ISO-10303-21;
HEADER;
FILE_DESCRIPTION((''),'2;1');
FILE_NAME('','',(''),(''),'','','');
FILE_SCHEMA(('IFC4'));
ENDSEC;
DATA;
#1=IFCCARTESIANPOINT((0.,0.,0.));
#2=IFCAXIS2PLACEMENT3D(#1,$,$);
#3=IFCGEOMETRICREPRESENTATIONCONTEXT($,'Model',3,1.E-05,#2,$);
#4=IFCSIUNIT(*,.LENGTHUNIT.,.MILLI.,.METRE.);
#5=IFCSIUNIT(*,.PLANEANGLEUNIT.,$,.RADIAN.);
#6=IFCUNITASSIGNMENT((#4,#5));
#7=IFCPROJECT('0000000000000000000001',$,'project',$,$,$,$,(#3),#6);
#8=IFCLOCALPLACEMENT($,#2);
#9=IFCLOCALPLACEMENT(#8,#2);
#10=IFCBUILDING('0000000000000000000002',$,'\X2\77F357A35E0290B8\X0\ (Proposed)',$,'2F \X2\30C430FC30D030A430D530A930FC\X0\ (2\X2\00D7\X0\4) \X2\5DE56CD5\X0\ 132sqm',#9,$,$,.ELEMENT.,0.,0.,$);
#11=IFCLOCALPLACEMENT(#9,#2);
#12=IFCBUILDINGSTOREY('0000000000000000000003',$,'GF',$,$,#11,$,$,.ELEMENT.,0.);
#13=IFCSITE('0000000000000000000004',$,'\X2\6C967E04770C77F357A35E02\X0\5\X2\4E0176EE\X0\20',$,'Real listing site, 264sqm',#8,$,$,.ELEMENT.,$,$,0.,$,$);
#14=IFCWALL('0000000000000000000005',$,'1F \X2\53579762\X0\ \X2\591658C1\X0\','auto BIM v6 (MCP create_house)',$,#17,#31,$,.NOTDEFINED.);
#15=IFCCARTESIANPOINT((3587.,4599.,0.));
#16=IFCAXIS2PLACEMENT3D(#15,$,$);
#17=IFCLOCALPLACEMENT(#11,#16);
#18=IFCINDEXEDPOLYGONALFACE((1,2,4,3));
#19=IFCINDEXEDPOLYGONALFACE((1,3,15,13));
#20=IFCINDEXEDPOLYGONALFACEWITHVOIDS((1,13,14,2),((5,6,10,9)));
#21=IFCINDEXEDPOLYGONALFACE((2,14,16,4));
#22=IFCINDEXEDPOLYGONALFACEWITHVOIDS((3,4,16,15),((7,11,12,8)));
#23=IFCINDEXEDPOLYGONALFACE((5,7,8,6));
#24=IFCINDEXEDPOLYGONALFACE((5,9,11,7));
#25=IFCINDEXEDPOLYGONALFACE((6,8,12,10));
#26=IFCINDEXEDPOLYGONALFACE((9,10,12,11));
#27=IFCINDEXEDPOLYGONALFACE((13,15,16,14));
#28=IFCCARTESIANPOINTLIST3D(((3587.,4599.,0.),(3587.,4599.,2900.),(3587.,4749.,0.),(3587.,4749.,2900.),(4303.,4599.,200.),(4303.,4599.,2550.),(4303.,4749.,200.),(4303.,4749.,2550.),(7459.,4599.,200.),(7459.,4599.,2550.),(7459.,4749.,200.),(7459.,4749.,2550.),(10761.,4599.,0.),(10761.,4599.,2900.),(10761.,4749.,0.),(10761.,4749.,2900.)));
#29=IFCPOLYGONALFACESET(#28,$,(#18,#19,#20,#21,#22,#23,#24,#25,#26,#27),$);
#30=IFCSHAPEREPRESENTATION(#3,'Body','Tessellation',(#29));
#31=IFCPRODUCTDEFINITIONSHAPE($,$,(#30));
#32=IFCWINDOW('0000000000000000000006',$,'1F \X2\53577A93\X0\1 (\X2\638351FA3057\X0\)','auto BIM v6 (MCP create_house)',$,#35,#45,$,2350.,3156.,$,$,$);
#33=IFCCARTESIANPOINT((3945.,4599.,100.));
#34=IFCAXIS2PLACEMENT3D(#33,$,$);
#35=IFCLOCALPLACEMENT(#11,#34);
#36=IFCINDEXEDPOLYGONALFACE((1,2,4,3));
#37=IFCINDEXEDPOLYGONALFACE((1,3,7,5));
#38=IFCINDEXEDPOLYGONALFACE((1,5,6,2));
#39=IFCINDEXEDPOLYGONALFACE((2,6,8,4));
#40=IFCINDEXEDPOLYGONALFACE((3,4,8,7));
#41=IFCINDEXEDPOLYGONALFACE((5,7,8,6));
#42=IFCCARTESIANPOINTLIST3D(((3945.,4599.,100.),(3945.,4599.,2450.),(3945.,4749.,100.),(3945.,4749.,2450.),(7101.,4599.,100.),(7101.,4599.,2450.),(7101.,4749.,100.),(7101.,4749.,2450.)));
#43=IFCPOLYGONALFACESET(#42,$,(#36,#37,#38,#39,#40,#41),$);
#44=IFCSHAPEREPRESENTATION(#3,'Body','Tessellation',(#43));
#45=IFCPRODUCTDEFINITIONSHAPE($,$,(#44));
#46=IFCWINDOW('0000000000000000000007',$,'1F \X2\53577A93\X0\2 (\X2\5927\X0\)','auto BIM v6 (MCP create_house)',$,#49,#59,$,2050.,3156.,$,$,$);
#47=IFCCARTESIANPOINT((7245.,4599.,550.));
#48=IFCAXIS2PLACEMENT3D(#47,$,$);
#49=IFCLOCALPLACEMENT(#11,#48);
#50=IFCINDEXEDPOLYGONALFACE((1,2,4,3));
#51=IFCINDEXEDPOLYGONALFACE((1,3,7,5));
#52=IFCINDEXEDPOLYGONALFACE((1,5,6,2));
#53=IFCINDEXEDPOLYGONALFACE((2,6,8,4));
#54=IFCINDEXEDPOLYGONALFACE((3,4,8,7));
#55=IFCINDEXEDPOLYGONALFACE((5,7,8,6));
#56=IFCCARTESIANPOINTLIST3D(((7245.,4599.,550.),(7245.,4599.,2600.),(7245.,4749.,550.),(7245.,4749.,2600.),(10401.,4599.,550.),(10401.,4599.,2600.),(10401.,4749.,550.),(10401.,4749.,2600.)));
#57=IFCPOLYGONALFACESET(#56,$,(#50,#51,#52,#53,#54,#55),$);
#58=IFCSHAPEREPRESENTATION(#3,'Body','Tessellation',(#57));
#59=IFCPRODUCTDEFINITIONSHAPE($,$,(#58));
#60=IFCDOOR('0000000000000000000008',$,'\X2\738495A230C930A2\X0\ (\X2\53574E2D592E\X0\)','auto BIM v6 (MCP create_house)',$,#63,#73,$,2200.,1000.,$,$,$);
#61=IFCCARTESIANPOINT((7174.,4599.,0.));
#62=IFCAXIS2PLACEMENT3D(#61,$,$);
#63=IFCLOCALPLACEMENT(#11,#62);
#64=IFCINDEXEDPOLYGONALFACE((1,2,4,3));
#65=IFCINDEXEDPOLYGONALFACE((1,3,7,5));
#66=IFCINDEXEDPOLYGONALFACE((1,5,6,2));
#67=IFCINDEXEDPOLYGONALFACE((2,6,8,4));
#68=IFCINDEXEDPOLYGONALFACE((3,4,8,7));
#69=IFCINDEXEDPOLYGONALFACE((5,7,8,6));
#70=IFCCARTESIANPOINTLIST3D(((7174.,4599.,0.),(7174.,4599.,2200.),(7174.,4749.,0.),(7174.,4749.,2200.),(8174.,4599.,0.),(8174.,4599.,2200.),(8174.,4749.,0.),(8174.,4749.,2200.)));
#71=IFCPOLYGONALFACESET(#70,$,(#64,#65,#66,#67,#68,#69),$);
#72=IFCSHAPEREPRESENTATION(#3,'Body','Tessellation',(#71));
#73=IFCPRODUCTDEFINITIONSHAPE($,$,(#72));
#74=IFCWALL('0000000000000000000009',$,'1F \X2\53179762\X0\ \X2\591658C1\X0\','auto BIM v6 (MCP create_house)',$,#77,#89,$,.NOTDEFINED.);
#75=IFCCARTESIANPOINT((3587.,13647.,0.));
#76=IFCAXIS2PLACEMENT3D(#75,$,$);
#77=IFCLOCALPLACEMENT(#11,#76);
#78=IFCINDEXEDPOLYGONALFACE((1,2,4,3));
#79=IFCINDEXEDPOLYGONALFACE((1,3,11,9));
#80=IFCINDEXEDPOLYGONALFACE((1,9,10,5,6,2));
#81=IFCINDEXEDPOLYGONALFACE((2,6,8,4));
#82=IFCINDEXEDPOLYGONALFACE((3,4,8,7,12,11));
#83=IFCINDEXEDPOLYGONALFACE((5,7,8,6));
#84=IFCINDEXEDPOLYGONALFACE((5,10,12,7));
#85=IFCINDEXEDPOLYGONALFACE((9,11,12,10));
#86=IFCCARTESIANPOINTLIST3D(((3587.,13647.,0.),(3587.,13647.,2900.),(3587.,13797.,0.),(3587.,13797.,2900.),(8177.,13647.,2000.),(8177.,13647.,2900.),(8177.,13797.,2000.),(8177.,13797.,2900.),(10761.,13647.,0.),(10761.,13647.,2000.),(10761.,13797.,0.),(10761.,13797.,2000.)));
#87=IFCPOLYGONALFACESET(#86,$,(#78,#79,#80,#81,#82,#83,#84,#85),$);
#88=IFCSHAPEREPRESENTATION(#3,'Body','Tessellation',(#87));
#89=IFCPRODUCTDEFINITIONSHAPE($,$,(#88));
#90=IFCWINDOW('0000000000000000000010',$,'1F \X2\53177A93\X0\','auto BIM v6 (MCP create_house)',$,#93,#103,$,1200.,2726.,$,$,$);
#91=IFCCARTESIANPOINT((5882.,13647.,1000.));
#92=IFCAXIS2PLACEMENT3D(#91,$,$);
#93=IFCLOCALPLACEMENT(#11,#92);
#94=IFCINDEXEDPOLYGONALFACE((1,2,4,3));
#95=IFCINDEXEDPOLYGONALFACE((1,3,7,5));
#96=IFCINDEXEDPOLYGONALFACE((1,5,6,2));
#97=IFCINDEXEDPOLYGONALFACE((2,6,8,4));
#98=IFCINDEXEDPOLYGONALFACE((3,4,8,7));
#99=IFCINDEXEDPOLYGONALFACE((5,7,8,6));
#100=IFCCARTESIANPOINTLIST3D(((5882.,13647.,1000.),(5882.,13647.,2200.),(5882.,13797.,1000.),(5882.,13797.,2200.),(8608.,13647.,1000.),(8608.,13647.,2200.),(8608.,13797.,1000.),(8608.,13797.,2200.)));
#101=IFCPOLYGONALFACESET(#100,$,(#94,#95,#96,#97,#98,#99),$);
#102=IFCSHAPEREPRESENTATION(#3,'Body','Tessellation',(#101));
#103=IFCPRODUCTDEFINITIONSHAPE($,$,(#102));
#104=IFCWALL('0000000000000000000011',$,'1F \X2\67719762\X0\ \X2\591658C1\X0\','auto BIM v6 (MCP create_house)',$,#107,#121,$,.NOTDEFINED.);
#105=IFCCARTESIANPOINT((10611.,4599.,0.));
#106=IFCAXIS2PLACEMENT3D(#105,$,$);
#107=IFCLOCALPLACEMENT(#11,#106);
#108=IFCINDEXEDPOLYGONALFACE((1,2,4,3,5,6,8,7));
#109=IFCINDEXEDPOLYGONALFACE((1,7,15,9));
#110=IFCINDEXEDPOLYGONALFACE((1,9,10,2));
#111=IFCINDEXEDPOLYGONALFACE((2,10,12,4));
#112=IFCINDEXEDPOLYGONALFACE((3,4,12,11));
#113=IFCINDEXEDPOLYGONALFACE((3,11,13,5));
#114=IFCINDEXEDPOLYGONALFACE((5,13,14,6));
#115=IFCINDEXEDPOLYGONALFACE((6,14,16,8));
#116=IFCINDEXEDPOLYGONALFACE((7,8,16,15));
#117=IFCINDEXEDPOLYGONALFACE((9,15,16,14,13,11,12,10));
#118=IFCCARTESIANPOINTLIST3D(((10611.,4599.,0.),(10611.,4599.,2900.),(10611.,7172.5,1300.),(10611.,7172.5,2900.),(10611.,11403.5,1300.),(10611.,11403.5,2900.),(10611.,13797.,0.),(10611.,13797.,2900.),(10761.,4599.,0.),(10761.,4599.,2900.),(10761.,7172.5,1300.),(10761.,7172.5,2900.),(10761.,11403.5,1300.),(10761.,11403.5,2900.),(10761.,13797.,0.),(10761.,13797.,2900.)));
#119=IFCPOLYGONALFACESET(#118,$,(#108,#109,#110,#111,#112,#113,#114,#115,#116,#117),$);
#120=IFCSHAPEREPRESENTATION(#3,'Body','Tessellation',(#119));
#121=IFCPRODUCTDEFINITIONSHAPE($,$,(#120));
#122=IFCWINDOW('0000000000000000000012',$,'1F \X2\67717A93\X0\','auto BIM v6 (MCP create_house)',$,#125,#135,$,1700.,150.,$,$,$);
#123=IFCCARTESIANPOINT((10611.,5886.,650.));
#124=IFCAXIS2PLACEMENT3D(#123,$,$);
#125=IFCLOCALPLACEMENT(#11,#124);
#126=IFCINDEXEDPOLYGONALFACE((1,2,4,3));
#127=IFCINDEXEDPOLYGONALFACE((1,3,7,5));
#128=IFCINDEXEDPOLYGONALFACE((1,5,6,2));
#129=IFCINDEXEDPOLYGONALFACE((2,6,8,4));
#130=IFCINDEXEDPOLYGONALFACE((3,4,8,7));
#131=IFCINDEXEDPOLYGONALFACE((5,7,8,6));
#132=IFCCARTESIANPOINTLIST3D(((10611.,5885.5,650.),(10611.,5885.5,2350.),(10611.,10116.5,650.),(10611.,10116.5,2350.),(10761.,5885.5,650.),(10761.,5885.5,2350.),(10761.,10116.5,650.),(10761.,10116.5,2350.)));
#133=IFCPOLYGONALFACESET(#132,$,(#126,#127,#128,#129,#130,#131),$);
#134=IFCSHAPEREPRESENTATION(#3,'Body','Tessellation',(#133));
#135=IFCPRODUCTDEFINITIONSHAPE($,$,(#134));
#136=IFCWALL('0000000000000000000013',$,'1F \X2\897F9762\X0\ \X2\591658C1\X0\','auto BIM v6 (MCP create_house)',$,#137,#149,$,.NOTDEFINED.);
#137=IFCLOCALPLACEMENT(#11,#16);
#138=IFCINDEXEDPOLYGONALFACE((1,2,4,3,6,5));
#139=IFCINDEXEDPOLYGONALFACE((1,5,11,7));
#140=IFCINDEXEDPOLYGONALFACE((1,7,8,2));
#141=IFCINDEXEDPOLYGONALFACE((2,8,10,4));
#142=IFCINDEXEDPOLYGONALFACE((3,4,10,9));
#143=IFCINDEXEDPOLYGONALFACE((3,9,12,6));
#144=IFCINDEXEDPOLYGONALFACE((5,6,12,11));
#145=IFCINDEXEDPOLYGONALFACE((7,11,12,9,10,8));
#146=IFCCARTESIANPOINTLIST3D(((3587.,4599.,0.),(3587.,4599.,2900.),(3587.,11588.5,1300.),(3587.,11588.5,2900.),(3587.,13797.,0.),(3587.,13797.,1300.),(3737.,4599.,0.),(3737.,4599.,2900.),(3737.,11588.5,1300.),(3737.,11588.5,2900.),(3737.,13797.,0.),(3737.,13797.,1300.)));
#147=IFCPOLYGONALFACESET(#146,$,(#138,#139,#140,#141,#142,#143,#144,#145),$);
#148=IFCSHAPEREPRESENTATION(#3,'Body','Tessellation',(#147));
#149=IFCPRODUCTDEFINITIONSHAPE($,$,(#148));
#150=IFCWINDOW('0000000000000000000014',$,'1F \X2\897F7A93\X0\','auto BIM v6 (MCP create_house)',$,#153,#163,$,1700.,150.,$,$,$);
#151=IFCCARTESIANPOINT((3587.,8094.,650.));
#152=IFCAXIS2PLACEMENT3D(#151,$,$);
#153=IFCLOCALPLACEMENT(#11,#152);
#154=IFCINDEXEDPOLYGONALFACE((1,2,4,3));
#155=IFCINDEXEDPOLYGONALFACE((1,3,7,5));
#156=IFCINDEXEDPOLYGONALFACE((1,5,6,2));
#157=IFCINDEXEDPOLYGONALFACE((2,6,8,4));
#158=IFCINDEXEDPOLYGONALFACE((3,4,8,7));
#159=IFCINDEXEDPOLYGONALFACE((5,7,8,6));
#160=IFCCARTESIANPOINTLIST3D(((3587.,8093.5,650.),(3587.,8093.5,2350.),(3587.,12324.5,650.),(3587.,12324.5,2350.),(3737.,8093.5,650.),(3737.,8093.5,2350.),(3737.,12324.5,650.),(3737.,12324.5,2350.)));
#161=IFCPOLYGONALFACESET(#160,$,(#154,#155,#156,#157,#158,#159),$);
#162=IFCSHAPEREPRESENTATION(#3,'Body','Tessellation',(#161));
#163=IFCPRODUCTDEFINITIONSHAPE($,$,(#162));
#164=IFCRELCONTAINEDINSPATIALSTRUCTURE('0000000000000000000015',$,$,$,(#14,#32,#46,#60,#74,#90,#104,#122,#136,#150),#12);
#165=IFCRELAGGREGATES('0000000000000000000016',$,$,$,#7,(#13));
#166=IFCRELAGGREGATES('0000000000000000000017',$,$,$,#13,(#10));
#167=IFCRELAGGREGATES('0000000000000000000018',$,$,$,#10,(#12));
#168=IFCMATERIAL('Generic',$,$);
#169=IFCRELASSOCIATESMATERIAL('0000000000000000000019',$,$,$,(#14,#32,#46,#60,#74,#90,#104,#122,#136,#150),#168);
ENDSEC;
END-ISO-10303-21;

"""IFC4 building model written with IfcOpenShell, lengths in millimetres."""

from ifc_helpers import new_model, si_unit, frame, frame_2d, origin, place, context, project, spatial, rectangle, extrude, material, element, fill, save


model = new_model("IFC4")

# Units and contexts
model_context = context("Model", 3, precision=1e-05, world=origin())
ifc_project = project(units=[si_unit("LENGTHUNIT", "METRE", prefix="MILLI"), si_unit("PLANEANGLEUNIT", "RADIAN")], contexts=[model_context])

# Site, building, storey
site_placement = place(None, origin())
site = spatial("IfcSite", under=ifc_project, at=site_placement, Name="沖縄県石垣市5丁目20", ObjectType="Real listing site, 264sqm", CompositionType="ELEMENT", RefElevation=0.0)
building_placement = place(site_placement, origin())
building = spatial("IfcBuilding", under=site, at=building_placement, Name="石垣市邸 (Proposed)", ObjectType="2F ツーバイフォー (2×4) 工法 132sqm", CompositionType="ELEMENT", ElevationOfRefHeight=0.0, ElevationOfTerrain=0.0)
storey_placement = place(building_placement, origin())
storey = spatial("IfcBuildingStorey", under=building, at=storey_placement, Name="GF", CompositionType="ELEMENT", Elevation=0.0)

# Shared definitions
ifc_material = material(Name="Generic")

# Wall, openings, windows, door
wall_1_placement = place(storey_placement, frame((3587.0, 4599.0, 0.0)))
wall_1 = element("IfcWall", 1, at=wall_1_placement, inside=storey, material=ifc_material, Name="1F 南面 外壁", Description="auto BIM v6 (MCP create_house)", PredefinedType="NOTDEFINED", context=model_context, shape_type="SweptSolid", body=[
    extrude(rectangle(XDim=7174.0, YDim=150.0, at=frame_2d((3587.0, 75.0))), frame((3587.0, 4599.0, 0.0)), (0.0, 0.0, 1.0), 2900.0),
])
opening_1_placement = place(storey_placement, frame((3945.0, 4599.0, 100.0)))
opening_1 = element("IfcOpeningElement", 2, at=opening_1_placement, cuts=wall_1, PredefinedType="NOTDEFINED", context=model_context, shape_type="SweptSolid", body=[
    extrude(rectangle(XDim=3156.0, YDim=150.0, at=frame_2d((1578.0, 75.0))), frame((3945.0, 4599.0, 100.0)), (0.0, 0.0, 1.0), 2350.0),
])
opening_2_placement = place(storey_placement, frame((7245.0, 4599.0, 550.0)))
opening_2 = element("IfcOpeningElement", 3, at=opening_2_placement, cuts=wall_1, PredefinedType="NOTDEFINED", context=model_context, shape_type="SweptSolid", body=[
    extrude(rectangle(XDim=3156.0, YDim=150.0, at=frame_2d((1578.0, 75.0))), frame((7245.0, 4599.0, 550.0)), (0.0, 0.0, 1.0), 2050.0),
])
opening_3_placement = place(storey_placement, frame((7174.0, 4599.0, 0.0)))
opening_3 = element("IfcOpeningElement", 4, at=opening_3_placement, cuts=wall_1, PredefinedType="NOTDEFINED", context=model_context, shape_type="SweptSolid", body=[
    extrude(rectangle(XDim=1000.0, YDim=150.0, at=frame_2d((500.0, 75.0))), frame((7174.0, 4599.0, 0.0)), (0.0, 0.0, 1.0), 2200.0),
])
window_1_placement = place(storey_placement, frame((3945.0, 4599.0, 100.0)))
window_1 = element("IfcWindow", 5, at=window_1_placement, inside=storey, material=ifc_material, Name="1F 南窓1 (掃出し)", Description="auto BIM v6 (MCP create_house)", OverallHeight=2350.0, OverallWidth=3156.0, context=model_context, shape_type="SweptSolid", body=[
    extrude(rectangle(XDim=3156.0, YDim=150.0, at=frame_2d((1578.0, 75.0))), frame((3945.0, 4599.0, 100.0)), (0.0, 0.0, 1.0), 2350.0),
])
fill(opening_1, window_1)
window_2_placement = place(storey_placement, frame((7245.0, 4599.0, 550.0)))
window_2 = element("IfcWindow", 6, at=window_2_placement, inside=storey, material=ifc_material, Name="1F 南窓2 (大)", Description="auto BIM v6 (MCP create_house)", OverallHeight=2050.0, OverallWidth=3156.0, context=model_context, shape_type="SweptSolid", body=[
    extrude(rectangle(XDim=3156.0, YDim=150.0, at=frame_2d((1578.0, 75.0))), frame((7245.0, 4599.0, 550.0)), (0.0, 0.0, 1.0), 2050.0),
])
fill(opening_2, window_2)
door_1_placement = place(storey_placement, frame((7174.0, 4599.0, 0.0)))
door_1 = element("IfcDoor", 7, at=door_1_placement, inside=storey, material=ifc_material, Name="玄関ドア (南中央)", Description="auto BIM v6 (MCP create_house)", OverallHeight=2200.0, OverallWidth=1000.0, context=model_context, shape_type="SweptSolid", body=[
    extrude(rectangle(XDim=1000.0, YDim=150.0, at=frame_2d((500.0, 75.0))), frame((7174.0, 4599.0, 0.0)), (0.0, 0.0, 1.0), 2200.0),
])
fill(opening_3, door_1)

# Walls, openings, windows
wall_2_placement = place(storey_placement, frame((3587.0, 13647.0, 0.0)))
wall_2 = element("IfcWall", 8, at=wall_2_placement, inside=storey, material=ifc_material, Name="1F 北面 外壁", Description="auto BIM v6 (MCP create_house)", PredefinedType="NOTDEFINED", context=model_context, shape_type="SweptSolid", body=[
    extrude(rectangle(XDim=7174.0, YDim=150.0, at=frame_2d((3587.0, 75.0))), frame((3587.0, 13647.0, 0.0)), (0.0, 0.0, 1.0), 2900.0),
])
opening_4_placement = place(storey_placement, frame((5882.0, 13647.0, 1000.0)))
opening_4 = element("IfcOpeningElement", 9, at=opening_4_placement, cuts=wall_2, PredefinedType="NOTDEFINED", context=model_context, shape_type="SweptSolid", body=[
    extrude(rectangle(XDim=2726.0, YDim=150.0, at=frame_2d((1363.0, 75.0))), frame((5882.0, 13647.0, 1000.0)), (0.0, 0.0, 1.0), 1200.0),
])
window_3_placement = place(storey_placement, frame((5882.0, 13647.0, 1000.0)))
window_3 = element("IfcWindow", 10, at=window_3_placement, inside=storey, material=ifc_material, Name="1F 北窓", Description="auto BIM v6 (MCP create_house)", OverallHeight=1200.0, OverallWidth=2726.0, context=model_context, shape_type="SweptSolid", body=[
    extrude(rectangle(XDim=2726.0, YDim=150.0, at=frame_2d((1363.0, 75.0))), frame((5882.0, 13647.0, 1000.0)), (0.0, 0.0, 1.0), 1200.0),
])
fill(opening_4, window_3)
wall_3_placement = place(storey_placement, frame((10611.0, 4599.0, 0.0)))
wall_3 = element("IfcWall", 11, at=wall_3_placement, inside=storey, material=ifc_material, Name="1F 東面 外壁", Description="auto BIM v6 (MCP create_house)", PredefinedType="NOTDEFINED", context=model_context, shape_type="SweptSolid", body=[
    extrude(rectangle(XDim=150.0, YDim=9198.0, at=frame_2d((75.0, 4599.0))), frame((10611.0, 4599.0, 0.0)), (0.0, 0.0, 1.0), 2900.0),
])
opening_5_placement = place(storey_placement, frame((10611.0, 5886.0, 650.0)))
opening_5 = element("IfcOpeningElement", 12, at=opening_5_placement, cuts=wall_3, PredefinedType="NOTDEFINED", context=model_context, shape_type="SweptSolid", body=[
    extrude(rectangle(XDim=150.0, YDim=4231.0, at=frame_2d((75.0, 2115.0))), frame((10611.0, 5886.0, 650.0)), (0.0, 0.0, 1.0), 1700.0),
])
window_4_placement = place(storey_placement, frame((10611.0, 5886.0, 650.0)))
window_4 = element("IfcWindow", 13, at=window_4_placement, inside=storey, material=ifc_material, Name="1F 東窓", Description="auto BIM v6 (MCP create_house)", OverallHeight=1700.0, OverallWidth=150.0, context=model_context, shape_type="SweptSolid", body=[
    extrude(rectangle(XDim=150.0, YDim=4231.0, at=frame_2d((75.0, 2115.0))), frame((10611.0, 5886.0, 650.0)), (0.0, 0.0, 1.0), 1700.0),
])
fill(opening_5, window_4)
wall_4_placement = place(storey_placement, frame((3587.0, 4599.0, 0.0)))
wall_4 = element("IfcWall", 14, at=wall_4_placement, inside=storey, material=ifc_material, Name="1F 西面 外壁", Description="auto BIM v6 (MCP create_house)", PredefinedType="NOTDEFINED", context=model_context, shape_type="SweptSolid", body=[
    extrude(rectangle(XDim=150.0, YDim=9198.0, at=frame_2d((75.0, 4599.0))), frame((3587.0, 4599.0, 0.0)), (0.0, 0.0, 1.0), 2900.0),
])
opening_6_placement = place(storey_placement, frame((3587.0, 8094.0, 650.0)))
opening_6 = element("IfcOpeningElement", 15, at=opening_6_placement, cuts=wall_4, PredefinedType="NOTDEFINED", context=model_context, shape_type="SweptSolid", body=[
    extrude(rectangle(XDim=150.0, YDim=4231.0, at=frame_2d((75.0, 2115.0))), frame((3587.0, 8094.0, 650.0)), (0.0, 0.0, 1.0), 1700.0),
])
window_5_placement = place(storey_placement, frame((3587.0, 8094.0, 650.0)))
window_5 = element("IfcWindow", 16, at=window_5_placement, inside=storey, material=ifc_material, Name="1F 西窓", Description="auto BIM v6 (MCP create_house)", OverallHeight=1700.0, OverallWidth=150.0, context=model_context, shape_type="SweptSolid", body=[
    extrude(rectangle(XDim=150.0, YDim=4231.0, at=frame_2d((75.0, 2115.0))), frame((3587.0, 8094.0, 650.0)), (0.0, 0.0, 1.0), 1700.0),
])
fill(opening_6, window_5)

save(model, "model.ifc")
